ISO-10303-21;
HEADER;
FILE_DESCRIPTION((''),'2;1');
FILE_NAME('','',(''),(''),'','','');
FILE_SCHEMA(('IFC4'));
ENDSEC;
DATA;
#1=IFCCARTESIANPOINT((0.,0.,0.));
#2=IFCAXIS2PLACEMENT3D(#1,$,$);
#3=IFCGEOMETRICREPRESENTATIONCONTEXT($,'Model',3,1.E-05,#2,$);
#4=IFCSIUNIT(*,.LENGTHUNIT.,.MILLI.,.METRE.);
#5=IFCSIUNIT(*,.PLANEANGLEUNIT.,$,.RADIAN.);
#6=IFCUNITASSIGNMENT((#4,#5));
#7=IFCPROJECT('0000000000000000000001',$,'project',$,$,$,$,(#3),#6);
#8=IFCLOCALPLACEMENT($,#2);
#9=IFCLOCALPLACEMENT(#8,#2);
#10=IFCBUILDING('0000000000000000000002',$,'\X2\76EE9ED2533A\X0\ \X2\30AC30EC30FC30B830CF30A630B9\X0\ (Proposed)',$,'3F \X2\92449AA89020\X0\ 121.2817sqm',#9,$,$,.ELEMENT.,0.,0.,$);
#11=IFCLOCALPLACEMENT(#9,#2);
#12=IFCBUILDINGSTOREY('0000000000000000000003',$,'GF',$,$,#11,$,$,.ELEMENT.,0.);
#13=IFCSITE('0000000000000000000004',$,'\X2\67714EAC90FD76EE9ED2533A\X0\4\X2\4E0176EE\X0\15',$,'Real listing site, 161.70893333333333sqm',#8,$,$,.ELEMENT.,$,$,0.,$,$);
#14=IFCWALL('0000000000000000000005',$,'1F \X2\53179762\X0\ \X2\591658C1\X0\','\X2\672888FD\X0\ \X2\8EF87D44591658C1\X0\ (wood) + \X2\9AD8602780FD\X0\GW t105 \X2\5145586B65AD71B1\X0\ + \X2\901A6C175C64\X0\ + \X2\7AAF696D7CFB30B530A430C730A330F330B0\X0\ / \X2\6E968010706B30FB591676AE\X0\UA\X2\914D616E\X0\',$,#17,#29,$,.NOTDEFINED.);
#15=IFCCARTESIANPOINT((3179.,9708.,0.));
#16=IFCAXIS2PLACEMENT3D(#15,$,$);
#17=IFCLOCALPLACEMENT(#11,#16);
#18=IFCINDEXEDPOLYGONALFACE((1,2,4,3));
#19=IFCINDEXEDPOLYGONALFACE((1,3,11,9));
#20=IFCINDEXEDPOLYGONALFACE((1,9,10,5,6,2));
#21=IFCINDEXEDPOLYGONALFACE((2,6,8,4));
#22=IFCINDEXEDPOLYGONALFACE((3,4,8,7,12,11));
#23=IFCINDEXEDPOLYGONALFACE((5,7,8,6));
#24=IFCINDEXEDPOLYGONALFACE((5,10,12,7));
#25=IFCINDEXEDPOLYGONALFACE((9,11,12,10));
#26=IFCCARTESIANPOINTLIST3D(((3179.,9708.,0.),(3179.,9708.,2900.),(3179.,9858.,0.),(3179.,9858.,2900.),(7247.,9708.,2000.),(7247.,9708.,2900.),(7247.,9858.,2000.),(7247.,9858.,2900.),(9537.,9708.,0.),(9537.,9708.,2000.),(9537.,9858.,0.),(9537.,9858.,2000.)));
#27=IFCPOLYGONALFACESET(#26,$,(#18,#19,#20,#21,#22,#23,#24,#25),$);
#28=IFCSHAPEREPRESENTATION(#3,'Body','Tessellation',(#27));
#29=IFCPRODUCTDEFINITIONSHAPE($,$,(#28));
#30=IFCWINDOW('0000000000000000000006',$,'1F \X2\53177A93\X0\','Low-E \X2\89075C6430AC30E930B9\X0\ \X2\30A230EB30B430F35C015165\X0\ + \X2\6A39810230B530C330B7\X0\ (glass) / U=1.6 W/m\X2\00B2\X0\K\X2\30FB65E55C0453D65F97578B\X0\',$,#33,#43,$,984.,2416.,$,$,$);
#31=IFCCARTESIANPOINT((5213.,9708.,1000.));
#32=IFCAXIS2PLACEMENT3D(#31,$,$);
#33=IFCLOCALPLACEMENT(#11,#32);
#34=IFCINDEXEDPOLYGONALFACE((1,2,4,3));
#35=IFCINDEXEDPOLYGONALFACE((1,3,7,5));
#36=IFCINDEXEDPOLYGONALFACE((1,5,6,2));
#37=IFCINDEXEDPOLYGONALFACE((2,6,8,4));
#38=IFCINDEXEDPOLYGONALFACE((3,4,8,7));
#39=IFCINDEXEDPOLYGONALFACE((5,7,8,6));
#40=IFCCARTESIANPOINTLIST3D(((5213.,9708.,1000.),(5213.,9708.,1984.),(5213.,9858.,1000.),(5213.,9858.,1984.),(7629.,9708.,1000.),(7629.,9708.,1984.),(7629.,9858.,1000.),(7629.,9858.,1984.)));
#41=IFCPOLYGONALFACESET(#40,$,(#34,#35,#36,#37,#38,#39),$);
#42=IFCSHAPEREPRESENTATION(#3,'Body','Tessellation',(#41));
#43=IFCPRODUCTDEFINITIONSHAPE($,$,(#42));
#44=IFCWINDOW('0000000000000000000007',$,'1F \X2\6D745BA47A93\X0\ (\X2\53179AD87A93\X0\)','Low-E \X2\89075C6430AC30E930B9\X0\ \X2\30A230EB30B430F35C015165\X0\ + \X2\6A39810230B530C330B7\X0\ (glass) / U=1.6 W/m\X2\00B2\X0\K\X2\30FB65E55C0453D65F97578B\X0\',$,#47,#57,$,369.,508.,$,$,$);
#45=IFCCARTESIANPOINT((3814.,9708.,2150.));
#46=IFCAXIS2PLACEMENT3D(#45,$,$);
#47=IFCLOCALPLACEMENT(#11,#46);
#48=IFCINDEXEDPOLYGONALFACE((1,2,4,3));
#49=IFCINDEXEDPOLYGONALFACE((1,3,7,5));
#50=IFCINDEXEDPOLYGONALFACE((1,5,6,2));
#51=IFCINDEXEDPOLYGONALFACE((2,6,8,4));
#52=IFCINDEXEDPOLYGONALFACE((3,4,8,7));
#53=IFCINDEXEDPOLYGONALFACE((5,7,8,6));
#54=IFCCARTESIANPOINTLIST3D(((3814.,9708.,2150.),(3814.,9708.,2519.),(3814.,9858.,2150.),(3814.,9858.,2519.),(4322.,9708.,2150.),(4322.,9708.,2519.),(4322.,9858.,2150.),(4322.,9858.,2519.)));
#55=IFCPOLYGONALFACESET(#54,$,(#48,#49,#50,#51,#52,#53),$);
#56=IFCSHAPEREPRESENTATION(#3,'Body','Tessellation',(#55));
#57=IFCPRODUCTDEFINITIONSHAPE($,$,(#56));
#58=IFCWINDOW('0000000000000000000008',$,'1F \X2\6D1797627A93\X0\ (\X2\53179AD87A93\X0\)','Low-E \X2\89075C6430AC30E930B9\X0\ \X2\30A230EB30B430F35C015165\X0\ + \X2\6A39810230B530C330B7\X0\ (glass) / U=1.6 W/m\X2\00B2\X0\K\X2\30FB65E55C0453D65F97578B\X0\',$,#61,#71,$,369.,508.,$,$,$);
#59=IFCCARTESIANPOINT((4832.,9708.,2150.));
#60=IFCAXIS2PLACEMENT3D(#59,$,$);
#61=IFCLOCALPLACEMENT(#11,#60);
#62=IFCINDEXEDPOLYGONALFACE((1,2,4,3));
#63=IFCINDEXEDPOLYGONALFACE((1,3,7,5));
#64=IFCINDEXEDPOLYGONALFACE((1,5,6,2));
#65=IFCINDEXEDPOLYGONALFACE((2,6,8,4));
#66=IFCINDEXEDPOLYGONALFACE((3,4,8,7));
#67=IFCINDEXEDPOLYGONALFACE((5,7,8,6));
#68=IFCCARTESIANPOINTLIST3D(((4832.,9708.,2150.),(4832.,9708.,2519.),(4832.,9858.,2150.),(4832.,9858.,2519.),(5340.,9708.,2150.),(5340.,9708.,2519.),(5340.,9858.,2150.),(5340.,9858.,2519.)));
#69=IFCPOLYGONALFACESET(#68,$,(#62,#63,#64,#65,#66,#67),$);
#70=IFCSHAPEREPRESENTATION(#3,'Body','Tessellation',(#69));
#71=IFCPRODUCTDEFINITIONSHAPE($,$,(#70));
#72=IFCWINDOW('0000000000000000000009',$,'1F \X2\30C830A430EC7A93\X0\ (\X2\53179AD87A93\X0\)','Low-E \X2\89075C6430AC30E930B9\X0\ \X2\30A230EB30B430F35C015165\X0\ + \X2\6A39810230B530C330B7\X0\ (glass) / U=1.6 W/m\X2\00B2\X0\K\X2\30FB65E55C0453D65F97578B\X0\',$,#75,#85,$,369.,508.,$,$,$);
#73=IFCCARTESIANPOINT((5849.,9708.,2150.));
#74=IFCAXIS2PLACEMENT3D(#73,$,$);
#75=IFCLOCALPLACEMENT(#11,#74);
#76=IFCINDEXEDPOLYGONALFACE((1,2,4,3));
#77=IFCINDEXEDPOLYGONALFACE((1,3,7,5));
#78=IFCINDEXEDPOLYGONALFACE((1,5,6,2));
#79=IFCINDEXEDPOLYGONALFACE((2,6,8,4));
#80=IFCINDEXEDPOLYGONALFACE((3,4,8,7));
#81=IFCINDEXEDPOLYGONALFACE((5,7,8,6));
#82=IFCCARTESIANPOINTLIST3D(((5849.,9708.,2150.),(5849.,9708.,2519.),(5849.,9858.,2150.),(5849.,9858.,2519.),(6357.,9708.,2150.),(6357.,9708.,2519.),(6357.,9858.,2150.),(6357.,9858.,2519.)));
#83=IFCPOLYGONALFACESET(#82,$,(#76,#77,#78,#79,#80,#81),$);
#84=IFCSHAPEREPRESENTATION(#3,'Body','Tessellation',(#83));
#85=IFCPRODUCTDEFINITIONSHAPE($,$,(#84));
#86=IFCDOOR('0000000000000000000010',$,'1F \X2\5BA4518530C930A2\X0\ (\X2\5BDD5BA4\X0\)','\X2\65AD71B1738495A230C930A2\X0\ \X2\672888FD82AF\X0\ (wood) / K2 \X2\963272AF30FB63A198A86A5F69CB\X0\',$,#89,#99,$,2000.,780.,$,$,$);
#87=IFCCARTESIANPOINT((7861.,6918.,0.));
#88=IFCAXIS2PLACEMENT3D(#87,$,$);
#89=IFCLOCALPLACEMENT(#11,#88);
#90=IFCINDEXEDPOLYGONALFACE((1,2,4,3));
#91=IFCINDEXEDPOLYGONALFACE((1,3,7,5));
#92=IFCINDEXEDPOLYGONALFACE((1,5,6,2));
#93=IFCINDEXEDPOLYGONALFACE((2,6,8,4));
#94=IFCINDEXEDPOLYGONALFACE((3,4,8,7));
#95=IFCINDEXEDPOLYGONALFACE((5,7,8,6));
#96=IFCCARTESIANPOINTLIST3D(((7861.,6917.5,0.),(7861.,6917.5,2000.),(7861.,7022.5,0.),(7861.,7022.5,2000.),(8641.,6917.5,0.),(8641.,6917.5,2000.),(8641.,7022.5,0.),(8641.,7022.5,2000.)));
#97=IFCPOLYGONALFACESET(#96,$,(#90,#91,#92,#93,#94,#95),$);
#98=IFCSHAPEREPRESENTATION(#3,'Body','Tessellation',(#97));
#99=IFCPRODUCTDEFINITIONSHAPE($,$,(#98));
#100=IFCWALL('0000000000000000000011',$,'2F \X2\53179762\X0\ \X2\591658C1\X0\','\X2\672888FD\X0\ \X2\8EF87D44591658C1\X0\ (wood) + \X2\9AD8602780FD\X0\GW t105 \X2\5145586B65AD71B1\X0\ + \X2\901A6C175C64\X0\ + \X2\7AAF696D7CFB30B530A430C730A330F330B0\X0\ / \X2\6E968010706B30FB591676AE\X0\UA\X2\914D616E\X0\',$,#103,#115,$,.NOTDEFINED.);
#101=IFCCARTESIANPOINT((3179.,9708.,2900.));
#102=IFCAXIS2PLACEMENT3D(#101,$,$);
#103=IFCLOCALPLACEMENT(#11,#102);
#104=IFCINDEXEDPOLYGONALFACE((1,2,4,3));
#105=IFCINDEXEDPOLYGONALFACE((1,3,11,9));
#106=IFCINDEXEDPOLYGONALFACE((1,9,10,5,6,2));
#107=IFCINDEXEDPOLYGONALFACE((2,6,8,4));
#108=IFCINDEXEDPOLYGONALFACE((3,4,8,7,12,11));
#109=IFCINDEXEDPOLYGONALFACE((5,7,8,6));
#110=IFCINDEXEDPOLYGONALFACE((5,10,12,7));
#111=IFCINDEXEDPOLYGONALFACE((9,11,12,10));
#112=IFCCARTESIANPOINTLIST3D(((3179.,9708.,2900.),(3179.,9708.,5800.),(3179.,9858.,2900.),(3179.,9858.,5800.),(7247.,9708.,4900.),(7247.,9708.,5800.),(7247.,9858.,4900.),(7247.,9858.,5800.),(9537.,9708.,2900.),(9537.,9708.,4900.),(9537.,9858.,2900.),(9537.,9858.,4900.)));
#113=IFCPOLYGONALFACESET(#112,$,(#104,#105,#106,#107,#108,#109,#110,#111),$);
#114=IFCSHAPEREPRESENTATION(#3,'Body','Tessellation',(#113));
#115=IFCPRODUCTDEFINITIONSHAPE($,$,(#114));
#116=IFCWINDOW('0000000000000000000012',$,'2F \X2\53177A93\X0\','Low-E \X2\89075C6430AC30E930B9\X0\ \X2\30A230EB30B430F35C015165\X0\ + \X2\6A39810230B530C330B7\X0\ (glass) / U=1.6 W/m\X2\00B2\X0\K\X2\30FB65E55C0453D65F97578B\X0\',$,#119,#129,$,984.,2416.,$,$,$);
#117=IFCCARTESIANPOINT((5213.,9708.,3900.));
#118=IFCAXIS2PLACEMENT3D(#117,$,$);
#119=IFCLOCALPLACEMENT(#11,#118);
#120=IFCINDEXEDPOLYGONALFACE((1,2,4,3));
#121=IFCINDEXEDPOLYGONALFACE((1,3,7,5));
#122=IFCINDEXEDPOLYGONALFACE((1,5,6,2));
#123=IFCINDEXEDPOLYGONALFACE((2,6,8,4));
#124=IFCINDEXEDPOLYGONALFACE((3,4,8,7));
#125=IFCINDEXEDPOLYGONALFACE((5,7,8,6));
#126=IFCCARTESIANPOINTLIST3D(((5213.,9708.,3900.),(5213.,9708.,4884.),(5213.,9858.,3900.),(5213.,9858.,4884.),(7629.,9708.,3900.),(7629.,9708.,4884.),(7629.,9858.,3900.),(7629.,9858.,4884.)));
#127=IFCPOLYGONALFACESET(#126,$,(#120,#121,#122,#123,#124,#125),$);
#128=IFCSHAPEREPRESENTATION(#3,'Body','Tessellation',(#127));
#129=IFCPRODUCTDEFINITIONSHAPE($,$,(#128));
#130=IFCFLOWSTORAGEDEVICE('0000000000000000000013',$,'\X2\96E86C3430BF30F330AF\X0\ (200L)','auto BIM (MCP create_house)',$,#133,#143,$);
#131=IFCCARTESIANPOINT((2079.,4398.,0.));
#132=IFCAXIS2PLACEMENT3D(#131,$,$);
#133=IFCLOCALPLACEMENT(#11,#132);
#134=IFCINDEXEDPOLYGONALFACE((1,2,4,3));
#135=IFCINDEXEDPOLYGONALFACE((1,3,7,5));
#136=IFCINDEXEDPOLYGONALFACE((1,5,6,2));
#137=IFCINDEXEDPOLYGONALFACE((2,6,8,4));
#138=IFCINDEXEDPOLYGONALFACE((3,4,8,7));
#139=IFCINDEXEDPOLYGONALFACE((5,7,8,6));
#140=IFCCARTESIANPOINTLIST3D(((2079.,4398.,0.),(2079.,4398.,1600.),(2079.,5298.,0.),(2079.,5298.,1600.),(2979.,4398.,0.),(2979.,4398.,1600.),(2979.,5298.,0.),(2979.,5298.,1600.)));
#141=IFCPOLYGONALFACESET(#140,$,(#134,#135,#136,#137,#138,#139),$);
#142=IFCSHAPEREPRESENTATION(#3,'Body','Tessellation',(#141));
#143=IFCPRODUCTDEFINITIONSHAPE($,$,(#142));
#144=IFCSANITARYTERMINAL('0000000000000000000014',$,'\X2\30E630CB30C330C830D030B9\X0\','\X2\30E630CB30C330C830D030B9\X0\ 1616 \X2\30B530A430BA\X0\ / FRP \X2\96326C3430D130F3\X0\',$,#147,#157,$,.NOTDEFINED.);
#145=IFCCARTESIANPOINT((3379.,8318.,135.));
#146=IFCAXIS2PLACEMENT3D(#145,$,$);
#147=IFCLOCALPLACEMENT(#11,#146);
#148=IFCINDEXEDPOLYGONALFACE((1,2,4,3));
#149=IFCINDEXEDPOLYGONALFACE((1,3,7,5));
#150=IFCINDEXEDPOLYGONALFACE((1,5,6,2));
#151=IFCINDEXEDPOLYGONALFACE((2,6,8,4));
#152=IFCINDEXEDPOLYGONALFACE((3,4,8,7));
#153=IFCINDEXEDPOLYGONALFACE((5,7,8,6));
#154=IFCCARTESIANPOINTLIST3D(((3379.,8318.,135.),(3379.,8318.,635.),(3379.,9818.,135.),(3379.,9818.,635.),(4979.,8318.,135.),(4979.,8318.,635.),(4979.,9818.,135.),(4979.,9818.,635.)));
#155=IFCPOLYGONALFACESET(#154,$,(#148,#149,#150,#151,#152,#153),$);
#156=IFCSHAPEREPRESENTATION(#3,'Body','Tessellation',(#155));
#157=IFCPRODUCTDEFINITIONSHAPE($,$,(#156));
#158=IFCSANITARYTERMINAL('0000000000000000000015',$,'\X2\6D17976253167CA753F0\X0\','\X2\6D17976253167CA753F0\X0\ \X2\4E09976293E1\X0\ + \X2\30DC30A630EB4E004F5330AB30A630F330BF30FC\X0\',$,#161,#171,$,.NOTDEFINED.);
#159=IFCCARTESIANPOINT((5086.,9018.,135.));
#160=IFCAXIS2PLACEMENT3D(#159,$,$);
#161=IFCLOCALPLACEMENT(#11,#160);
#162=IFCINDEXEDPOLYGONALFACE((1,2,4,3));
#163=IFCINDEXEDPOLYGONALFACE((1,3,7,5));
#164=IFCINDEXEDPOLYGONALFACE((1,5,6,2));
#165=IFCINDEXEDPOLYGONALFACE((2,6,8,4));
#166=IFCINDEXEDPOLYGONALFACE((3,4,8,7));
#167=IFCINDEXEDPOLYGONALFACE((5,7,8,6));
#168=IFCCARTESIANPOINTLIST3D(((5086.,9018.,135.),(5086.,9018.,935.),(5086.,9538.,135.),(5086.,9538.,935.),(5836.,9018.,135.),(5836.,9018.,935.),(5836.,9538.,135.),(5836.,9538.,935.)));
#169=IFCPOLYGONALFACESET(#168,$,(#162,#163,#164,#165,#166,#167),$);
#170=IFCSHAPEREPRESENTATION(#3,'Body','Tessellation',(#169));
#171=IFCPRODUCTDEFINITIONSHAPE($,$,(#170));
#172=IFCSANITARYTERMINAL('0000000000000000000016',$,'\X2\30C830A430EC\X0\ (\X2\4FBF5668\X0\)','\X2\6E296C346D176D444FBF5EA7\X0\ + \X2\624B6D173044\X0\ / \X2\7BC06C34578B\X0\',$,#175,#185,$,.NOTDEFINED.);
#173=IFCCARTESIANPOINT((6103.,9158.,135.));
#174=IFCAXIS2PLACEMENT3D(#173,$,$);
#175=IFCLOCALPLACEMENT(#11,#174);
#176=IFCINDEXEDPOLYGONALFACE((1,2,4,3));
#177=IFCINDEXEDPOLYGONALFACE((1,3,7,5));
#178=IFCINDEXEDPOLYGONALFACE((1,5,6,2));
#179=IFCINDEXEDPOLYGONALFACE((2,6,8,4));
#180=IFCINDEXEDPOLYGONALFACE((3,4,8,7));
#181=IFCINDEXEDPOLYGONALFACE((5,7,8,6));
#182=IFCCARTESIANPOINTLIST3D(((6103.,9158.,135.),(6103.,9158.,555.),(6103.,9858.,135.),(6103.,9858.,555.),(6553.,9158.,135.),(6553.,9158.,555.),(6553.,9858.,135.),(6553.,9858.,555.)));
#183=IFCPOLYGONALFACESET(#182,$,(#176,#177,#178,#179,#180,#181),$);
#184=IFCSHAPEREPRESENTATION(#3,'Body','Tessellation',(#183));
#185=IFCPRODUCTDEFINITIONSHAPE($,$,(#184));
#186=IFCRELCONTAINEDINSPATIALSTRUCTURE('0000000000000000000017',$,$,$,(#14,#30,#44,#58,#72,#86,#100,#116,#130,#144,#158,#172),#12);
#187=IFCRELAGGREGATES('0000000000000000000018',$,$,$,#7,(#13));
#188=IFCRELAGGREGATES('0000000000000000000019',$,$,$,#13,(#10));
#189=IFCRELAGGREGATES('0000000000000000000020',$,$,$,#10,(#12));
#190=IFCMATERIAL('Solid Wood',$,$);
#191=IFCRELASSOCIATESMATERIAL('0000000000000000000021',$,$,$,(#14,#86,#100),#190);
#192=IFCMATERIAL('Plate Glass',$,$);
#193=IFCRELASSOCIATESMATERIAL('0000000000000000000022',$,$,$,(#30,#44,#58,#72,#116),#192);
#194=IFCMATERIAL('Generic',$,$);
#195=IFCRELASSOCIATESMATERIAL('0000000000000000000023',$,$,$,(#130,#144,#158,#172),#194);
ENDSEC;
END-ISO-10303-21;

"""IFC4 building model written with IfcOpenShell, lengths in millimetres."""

from ifc_helpers import new_model, si_unit, frame, frame_2d, origin, place, context, project, spatial, rectangle, extrude, material, element, fill, save


model = new_model("IFC4")

# Units and contexts
model_context = context("Model", 3, precision=1e-05, world=origin())
ifc_project = project(units=[si_unit("LENGTHUNIT", "METRE", prefix="MILLI"), si_unit("PLANEANGLEUNIT", "RADIAN")], contexts=[model_context])

# Site, building, storey
site_placement = place(None, origin())
site = spatial("IfcSite", under=ifc_project, at=site_placement, Name="東京都目黒区4丁目15", ObjectType="Real listing site, 161.70893333333333sqm", CompositionType="ELEMENT", RefElevation=0.0)
building_placement = place(site_placement, origin())
building = spatial("IfcBuilding", under=site, at=building_placement, Name="目黒区 ガレージハウス (Proposed)", ObjectType="3F 鉄骨造 121.2817sqm", CompositionType="ELEMENT", ElevationOfRefHeight=0.0, ElevationOfTerrain=0.0)
storey_placement = place(building_placement, origin())
storey = spatial("IfcBuildingStorey", under=building, at=storey_placement, Name="GF", CompositionType="ELEMENT", Elevation=0.0)

# Wall, openings, windows
ifc_material_1 = material(Name="Solid Wood")
wall_1_placement = place(storey_placement, frame((3179.0, 9708.0, 0.0)))
wall_1 = element("IfcWall", 1, at=wall_1_placement, inside=storey, material=ifc_material_1, Name="1F 北面 外壁", Description="木製 軸組外壁 (wood) + 高性能GW t105 充填断熱 + 通気層 + 窯業系サイディング / 準耐火・外皮UA配慮", PredefinedType="NOTDEFINED", context=model_context, shape_type="SweptSolid", body=[
    extrude(rectangle(XDim=6358.0, YDim=150.0, at=frame_2d((3179.0, 75.0))), frame((3179.0, 9708.0, 0.0)), (0.0, 0.0, 1.0), 2900.0),
])
opening_1_placement = place(storey_placement, frame((5213.0, 9708.0, 1000.0)))
opening_1 = element("IfcOpeningElement", 2, at=opening_1_placement, cuts=wall_1, PredefinedType="NOTDEFINED", context=model_context, shape_type="SweptSolid", body=[
    extrude(rectangle(XDim=2416.0, YDim=150.0, at=frame_2d((1208.0, 75.0))), frame((5213.0, 9708.0, 1000.0)), (0.0, 0.0, 1.0), 984.0),
])
opening_2_placement = place(storey_placement, frame((3814.0, 9708.0, 2150.0)))
opening_2 = element("IfcOpeningElement", 3, at=opening_2_placement, cuts=wall_1, PredefinedType="NOTDEFINED", context=model_context, shape_type="SweptSolid", body=[
    extrude(rectangle(XDim=508.0, YDim=150.0, at=frame_2d((254.0, 75.0))), frame((3814.0, 9708.0, 2150.0)), (0.0, 0.0, 1.0), 369.0),
])
opening_3_placement = place(storey_placement, frame((4832.0, 9708.0, 2150.0)))
opening_3 = element("IfcOpeningElement", 4, at=opening_3_placement, cuts=wall_1, PredefinedType="NOTDEFINED", context=model_context, shape_type="SweptSolid", body=[
    extrude(rectangle(XDim=508.0, YDim=150.0, at=frame_2d((254.0, 75.0))), frame((4832.0, 9708.0, 2150.0)), (0.0, 0.0, 1.0), 369.0),
])
opening_4_placement = place(storey_placement, frame((5849.0, 9708.0, 2150.0)))
opening_4 = element("IfcOpeningElement", 5, at=opening_4_placement, cuts=wall_1, PredefinedType="NOTDEFINED", context=model_context, shape_type="SweptSolid", body=[
    extrude(rectangle(XDim=508.0, YDim=150.0, at=frame_2d((254.0, 75.0))), frame((5849.0, 9708.0, 2150.0)), (0.0, 0.0, 1.0), 369.0),
])
ifc_material_2 = material(Name="Plate Glass")
window_1_placement = place(storey_placement, frame((5213.0, 9708.0, 1000.0)))
window_1 = element("IfcWindow", 6, at=window_1_placement, inside=storey, material=ifc_material_2, Name="1F 北窓", Description="Low-E 複層ガラス アルゴン封入 + 樹脂サッシ (glass) / U=1.6 W/m²K・日射取得型", OverallHeight=984.0, OverallWidth=2416.0, context=model_context, shape_type="SweptSolid", body=[
    extrude(rectangle(XDim=2416.0, YDim=150.0, at=frame_2d((1208.0, 75.0))), frame((5213.0, 9708.0, 1000.0)), (0.0, 0.0, 1.0), 984.0),
])
fill(opening_1, window_1)
window_2_placement = place(storey_placement, frame((3814.0, 9708.0, 2150.0)))
window_2 = element("IfcWindow", 7, at=window_2_placement, inside=storey, material=ifc_material_2, Name="1F 浴室窓 (北高窓)", Description="Low-E 複層ガラス アルゴン封入 + 樹脂サッシ (glass) / U=1.6 W/m²K・日射取得型", OverallHeight=369.0, OverallWidth=508.0, context=model_context, shape_type="SweptSolid", body=[
    extrude(rectangle(XDim=508.0, YDim=150.0, at=frame_2d((254.0, 75.0))), frame((3814.0, 9708.0, 2150.0)), (0.0, 0.0, 1.0), 369.0),
])
fill(opening_2, window_2)
window_3_placement = place(storey_placement, frame((4832.0, 9708.0, 2150.0)))
window_3 = element("IfcWindow", 8, at=window_3_placement, inside=storey, material=ifc_material_2, Name="1F 洗面窓 (北高窓)", Description="Low-E 複層ガラス アルゴン封入 + 樹脂サッシ (glass) / U=1.6 W/m²K・日射取得型", OverallHeight=369.0, OverallWidth=508.0, context=model_context, shape_type="SweptSolid", body=[
    extrude(rectangle(XDim=508.0, YDim=150.0, at=frame_2d((254.0, 75.0))), frame((4832.0, 9708.0, 2150.0)), (0.0, 0.0, 1.0), 369.0),
])
fill(opening_3, window_3)
window_4_placement = place(storey_placement, frame((5849.0, 9708.0, 2150.0)))
window_4 = element("IfcWindow", 9, at=window_4_placement, inside=storey, material=ifc_material_2, Name="1F トイレ窓 (北高窓)", Description="Low-E 複層ガラス アルゴン封入 + 樹脂サッシ (glass) / U=1.6 W/m²K・日射取得型", OverallHeight=369.0, OverallWidth=508.0, context=model_context, shape_type="SweptSolid", body=[
    extrude(rectangle(XDim=508.0, YDim=150.0, at=frame_2d((254.0, 75.0))), frame((5849.0, 9708.0, 2150.0)), (0.0, 0.0, 1.0), 369.0),
])
fill(opening_4, window_4)

# Door
door_1_placement = place(storey_placement, frame((7861.0, 6918.0, 0.0)))
element("IfcDoor", 10, at=door_1_placement, inside=storey, material=ifc_material_1, Name="1F 室内ドア (寝室)", Description="断熱玄関ドア 木製芯 (wood) / K2 防犯・採風機構", OverallHeight=2000.0, OverallWidth=780.0, context=model_context, shape_type="SweptSolid", body=[
    extrude(rectangle(XDim=780.0, YDim=105.0, at=frame_2d((390.0, 52.0))), frame((7861.0, 6918.0, 0.0)), (0.0, 0.0, 1.0), 2000.0),
])

# Wall, opening, window
wall_2_placement = place(storey_placement, frame((3179.0, 9708.0, 2900.0)))
wall_2 = element("IfcWall", 11, at=wall_2_placement, inside=storey, material=ifc_material_1, Name="2F 北面 外壁", Description="木製 軸組外壁 (wood) + 高性能GW t105 充填断熱 + 通気層 + 窯業系サイディング / 準耐火・外皮UA配慮", PredefinedType="NOTDEFINED", context=model_context, shape_type="SweptSolid", body=[
    extrude(rectangle(XDim=6358.0, YDim=150.0, at=frame_2d((3179.0, 75.0))), frame((3179.0, 9708.0, 2900.0)), (0.0, 0.0, 1.0), 2900.0),
])
opening_5_placement = place(storey_placement, frame((5213.0, 9708.0, 3900.0)))
opening_5 = element("IfcOpeningElement", 12, at=opening_5_placement, cuts=wall_2, PredefinedType="NOTDEFINED", context=model_context, shape_type="SweptSolid", body=[
    extrude(rectangle(XDim=2416.0, YDim=150.0, at=frame_2d((1208.0, 75.0))), frame((5213.0, 9708.0, 3900.0)), (0.0, 0.0, 1.0), 984.0),
])
window_5_placement = place(storey_placement, frame((5213.0, 9708.0, 3900.0)))
window_5 = element("IfcWindow", 13, at=window_5_placement, inside=storey, material=ifc_material_2, Name="2F 北窓", Description="Low-E 複層ガラス アルゴン封入 + 樹脂サッシ (glass) / U=1.6 W/m²K・日射取得型", OverallHeight=984.0, OverallWidth=2416.0, context=model_context, shape_type="SweptSolid", body=[
    extrude(rectangle(XDim=2416.0, YDim=150.0, at=frame_2d((1208.0, 75.0))), frame((5213.0, 9708.0, 3900.0)), (0.0, 0.0, 1.0), 984.0),
])
fill(opening_5, window_5)

# Flow storage device
ifc_material_3 = material(Name="Generic")
flow_storage_device_placement = place(storey_placement, frame((2079.0, 4398.0, 0.0)))
element("IfcFlowStorageDevice", 14, at=flow_storage_device_placement, inside=storey, material=ifc_material_3, Name="雨水タンク (200L)", Description="auto BIM (MCP create_house)", context=model_context, shape_type="SweptSolid", body=[
    extrude(rectangle(XDim=900.0, YDim=900.0, at=frame_2d((450.0, 450.0))), frame((2079.0, 4398.0, 0.0)), (0.0, 0.0, 1.0), 1600.0),
])

# Sanitary terminals
sanitary_terminal_1_placement = place(storey_placement, frame((3379.0, 8318.0, 135.0)))
element("IfcSanitaryTerminal", 15, at=sanitary_terminal_1_placement, inside=storey, material=ifc_material_3, Name="ユニットバス", Description="ユニットバス 1616 サイズ / FRP 防水パン", PredefinedType="NOTDEFINED", context=model_context, shape_type="SweptSolid", body=[
    extrude(rectangle(XDim=1600.0, YDim=1500.0, at=frame_2d((800.0, 750.0))), frame((3379.0, 8318.0, 135.0)), (0.0, 0.0, 1.0), 500.0),
])
sanitary_terminal_2_placement = place(storey_placement, frame((5086.0, 9018.0, 135.0)))
element("IfcSanitaryTerminal", 16, at=sanitary_terminal_2_placement, inside=storey, material=ifc_material_3, Name="洗面化粧台", Description="洗面化粧台 三面鏡 + ボウル一体カウンター", PredefinedType="NOTDEFINED", context=model_context, shape_type="SweptSolid", body=[
    extrude(rectangle(XDim=750.0, YDim=520.0, at=frame_2d((375.0, 260.0))), frame((5086.0, 9018.0, 135.0)), (0.0, 0.0, 1.0), 800.0),
])
sanitary_terminal_3_placement = place(storey_placement, frame((6103.0, 9158.0, 135.0)))
element("IfcSanitaryTerminal", 17, at=sanitary_terminal_3_placement, inside=storey, material=ifc_material_3, Name="トイレ (便器)", Description="温水洗浄便座 + 手洗い / 節水型", PredefinedType="NOTDEFINED", context=model_context, shape_type="SweptSolid", body=[
    extrude(rectangle(XDim=450.0, YDim=700.0, at=frame_2d((225.0, 350.0))), frame((6103.0, 9158.0, 135.0)), (0.0, 0.0, 1.0), 420.0),
])

save(model, "model.ifc")
